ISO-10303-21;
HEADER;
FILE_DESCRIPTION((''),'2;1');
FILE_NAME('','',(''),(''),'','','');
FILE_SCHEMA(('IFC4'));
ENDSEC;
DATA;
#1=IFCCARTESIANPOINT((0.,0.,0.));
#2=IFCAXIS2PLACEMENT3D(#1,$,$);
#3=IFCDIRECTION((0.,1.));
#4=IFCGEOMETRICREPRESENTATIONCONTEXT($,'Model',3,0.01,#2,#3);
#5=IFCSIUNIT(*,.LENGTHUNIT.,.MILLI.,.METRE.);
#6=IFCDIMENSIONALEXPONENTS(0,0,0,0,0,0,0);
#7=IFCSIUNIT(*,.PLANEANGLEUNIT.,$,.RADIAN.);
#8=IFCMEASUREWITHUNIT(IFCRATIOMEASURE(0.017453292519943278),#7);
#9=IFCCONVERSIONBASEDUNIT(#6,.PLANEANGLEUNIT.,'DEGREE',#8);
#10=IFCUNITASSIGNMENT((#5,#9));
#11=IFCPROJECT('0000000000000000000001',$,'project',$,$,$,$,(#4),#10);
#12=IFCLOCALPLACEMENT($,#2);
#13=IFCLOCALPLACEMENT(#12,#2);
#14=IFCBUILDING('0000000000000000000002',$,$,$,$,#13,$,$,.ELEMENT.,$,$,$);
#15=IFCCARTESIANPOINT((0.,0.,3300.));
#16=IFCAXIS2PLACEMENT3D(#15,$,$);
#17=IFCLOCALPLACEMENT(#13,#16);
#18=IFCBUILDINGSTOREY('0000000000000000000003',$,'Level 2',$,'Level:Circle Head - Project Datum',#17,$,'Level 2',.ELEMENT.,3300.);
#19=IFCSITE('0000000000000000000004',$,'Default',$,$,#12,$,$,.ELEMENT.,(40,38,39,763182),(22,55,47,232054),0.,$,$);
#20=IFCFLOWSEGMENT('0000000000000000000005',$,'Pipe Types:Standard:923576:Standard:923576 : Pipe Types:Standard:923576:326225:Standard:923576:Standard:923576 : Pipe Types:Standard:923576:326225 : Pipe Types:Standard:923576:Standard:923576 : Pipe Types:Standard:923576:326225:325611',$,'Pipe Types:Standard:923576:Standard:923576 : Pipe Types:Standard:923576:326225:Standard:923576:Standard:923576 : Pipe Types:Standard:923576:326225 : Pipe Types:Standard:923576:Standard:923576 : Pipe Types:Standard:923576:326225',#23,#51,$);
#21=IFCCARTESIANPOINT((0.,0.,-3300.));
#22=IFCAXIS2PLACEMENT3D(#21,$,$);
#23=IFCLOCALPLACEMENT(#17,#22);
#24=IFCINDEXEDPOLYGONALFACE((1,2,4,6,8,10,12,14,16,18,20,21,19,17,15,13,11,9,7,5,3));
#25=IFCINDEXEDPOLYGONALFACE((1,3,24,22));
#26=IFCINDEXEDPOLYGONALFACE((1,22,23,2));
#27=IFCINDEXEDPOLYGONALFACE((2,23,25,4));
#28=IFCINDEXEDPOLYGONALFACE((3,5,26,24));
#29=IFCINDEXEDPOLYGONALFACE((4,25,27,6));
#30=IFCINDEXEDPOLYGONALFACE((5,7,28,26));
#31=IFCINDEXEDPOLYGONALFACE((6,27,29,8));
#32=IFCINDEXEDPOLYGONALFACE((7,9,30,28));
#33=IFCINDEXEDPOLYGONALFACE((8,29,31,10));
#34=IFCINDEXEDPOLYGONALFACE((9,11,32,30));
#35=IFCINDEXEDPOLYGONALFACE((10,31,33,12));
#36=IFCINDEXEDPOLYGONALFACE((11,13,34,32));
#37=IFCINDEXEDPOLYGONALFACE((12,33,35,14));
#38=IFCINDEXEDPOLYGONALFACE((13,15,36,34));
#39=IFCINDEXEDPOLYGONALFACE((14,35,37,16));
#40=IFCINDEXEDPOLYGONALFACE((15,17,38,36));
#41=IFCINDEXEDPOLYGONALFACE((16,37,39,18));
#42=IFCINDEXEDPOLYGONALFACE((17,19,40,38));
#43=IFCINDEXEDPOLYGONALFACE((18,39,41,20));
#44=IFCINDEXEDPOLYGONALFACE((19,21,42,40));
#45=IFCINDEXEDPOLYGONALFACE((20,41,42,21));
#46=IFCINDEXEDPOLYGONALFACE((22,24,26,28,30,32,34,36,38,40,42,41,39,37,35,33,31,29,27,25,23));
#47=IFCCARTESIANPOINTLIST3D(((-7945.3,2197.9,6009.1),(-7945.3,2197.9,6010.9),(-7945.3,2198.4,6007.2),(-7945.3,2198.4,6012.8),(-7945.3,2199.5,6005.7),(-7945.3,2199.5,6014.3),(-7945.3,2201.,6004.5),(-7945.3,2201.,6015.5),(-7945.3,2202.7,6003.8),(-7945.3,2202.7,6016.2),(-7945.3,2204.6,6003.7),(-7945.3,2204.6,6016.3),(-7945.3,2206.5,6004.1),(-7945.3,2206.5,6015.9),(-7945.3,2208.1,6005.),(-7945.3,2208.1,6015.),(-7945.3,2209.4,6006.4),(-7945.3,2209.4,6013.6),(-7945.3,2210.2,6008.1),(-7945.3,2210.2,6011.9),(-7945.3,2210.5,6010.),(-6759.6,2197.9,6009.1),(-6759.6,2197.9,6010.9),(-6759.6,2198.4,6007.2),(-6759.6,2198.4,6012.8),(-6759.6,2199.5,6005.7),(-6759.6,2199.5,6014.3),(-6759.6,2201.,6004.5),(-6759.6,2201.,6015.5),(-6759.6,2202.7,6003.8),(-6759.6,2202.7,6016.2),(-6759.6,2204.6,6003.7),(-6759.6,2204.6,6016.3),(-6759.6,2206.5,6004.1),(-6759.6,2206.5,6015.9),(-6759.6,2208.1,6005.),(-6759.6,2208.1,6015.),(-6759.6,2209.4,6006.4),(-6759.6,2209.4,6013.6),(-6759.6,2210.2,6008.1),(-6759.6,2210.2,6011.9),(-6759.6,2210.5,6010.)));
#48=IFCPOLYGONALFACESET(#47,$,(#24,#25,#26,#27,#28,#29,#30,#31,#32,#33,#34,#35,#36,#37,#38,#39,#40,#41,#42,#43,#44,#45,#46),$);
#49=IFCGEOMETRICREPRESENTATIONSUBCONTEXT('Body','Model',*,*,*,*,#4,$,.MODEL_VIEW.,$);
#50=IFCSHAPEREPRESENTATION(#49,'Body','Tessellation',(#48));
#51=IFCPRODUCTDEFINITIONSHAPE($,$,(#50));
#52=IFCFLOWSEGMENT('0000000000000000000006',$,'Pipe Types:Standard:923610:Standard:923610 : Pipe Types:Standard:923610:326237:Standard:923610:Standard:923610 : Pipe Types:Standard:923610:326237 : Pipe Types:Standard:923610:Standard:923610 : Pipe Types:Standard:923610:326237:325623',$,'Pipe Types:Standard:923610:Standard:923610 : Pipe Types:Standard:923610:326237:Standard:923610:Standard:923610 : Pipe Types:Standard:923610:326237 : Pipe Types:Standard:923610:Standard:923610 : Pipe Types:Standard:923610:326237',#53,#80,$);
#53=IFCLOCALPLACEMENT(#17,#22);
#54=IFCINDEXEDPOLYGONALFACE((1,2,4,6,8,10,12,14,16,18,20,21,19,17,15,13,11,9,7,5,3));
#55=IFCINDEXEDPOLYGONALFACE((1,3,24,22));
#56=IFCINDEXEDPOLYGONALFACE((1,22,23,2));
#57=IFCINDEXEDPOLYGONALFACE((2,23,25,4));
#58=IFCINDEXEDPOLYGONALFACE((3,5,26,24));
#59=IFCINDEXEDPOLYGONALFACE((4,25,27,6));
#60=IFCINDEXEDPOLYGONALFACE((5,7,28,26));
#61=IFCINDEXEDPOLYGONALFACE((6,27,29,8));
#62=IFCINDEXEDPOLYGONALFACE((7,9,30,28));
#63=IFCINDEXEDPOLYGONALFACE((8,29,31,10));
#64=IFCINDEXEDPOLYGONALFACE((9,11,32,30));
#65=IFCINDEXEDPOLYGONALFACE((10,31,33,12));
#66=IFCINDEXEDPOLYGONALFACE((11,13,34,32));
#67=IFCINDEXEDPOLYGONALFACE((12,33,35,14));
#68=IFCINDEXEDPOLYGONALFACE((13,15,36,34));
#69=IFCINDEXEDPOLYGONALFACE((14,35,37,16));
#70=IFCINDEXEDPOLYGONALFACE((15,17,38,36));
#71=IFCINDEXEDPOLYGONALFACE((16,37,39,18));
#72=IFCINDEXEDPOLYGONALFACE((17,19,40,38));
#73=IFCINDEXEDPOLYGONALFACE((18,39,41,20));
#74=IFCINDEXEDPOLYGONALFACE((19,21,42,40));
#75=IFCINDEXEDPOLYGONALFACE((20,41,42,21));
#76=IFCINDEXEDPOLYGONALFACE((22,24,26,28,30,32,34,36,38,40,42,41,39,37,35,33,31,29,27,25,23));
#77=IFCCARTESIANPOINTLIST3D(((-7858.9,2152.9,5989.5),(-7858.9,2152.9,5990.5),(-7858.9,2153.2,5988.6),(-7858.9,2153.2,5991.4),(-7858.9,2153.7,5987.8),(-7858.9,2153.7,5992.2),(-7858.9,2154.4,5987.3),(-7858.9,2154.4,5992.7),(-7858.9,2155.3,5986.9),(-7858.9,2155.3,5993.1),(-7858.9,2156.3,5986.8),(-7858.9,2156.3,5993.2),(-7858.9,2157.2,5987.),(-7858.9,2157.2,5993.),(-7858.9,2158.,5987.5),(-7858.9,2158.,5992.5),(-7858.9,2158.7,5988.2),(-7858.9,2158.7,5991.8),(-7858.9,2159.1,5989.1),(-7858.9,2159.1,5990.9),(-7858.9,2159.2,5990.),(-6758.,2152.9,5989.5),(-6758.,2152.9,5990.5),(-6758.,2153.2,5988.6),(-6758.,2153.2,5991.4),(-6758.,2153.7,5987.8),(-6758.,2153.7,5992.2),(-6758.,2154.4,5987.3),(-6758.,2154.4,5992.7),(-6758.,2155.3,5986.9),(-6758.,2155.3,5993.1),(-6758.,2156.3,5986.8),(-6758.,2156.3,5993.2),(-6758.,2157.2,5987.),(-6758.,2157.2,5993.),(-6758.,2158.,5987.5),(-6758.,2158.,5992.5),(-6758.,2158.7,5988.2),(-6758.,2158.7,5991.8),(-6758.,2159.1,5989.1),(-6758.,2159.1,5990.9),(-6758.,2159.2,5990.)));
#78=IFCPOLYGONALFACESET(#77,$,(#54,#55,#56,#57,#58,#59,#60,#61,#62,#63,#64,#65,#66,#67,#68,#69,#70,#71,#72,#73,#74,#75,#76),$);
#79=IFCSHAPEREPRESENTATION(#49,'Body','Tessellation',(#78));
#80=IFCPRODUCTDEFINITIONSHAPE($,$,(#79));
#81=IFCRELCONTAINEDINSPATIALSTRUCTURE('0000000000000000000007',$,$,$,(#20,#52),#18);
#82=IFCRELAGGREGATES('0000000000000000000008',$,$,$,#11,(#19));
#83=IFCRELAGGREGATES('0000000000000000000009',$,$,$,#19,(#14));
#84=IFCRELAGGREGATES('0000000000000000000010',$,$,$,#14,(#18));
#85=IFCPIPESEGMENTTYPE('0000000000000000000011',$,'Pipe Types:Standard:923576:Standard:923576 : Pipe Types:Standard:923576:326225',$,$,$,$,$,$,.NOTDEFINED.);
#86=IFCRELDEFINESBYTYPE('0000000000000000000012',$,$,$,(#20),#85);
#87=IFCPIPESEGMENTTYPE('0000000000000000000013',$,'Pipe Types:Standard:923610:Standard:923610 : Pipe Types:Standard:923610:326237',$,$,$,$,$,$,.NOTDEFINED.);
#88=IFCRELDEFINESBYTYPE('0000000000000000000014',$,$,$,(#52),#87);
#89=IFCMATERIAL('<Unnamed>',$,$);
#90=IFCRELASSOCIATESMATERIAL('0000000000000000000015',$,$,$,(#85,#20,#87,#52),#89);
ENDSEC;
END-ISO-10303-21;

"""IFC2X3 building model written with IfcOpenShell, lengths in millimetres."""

from ifc_helpers import new_model, entity, si_unit, converted_unit, direction, frame, origin, origin_2d_with_axis, place, context, subcontext, project, spatial, circle, extrude, source, transform, mapped, material, type_object, type_shapes, element, save


model = new_model("IFC2X3")

# Units and contexts
model_context = context("Model", 3, precision=0.01, world=origin(), true_north=direction((0.0, 1.0)))
body_context = subcontext(model_context, "Body", "Model", "MODEL_VIEW")
ifc_project = project(units=[si_unit("LENGTHUNIT", "METRE", prefix="MILLI"), converted_unit("PLANEANGLEUNIT", "DEGREE", entity("IfcRatioMeasure", 0.017453292519943278), si_unit("PLANEANGLEUNIT", "RADIAN"), dimensions=[0, 0, 0, 0, 0, 0, 0])], contexts=[model_context])

# Site, building, storey
site_placement = place(None, origin())
site = spatial("IfcSite", under=ifc_project, at=site_placement, Name="Default", CompositionType="ELEMENT", RefLatitude=(40, 38, 39, 763182), RefLongitude=(22, 55, 47, 232054), RefElevation=0.0)
building_placement = place(site_placement, origin())
building = spatial("IfcBuilding", under=site, at=building_placement, CompositionType="ELEMENT")
storey_placement = place(building_placement, frame((0.0, 0.0, 3300.0)))
storey = spatial("IfcBuildingStorey", under=building, at=storey_placement, Name="Level 2", ObjectType="Level:Circle Head - Project Datum", LongName="Level 2", CompositionType="ELEMENT", Elevation=3300.0)

# Flow segments
ifc_material = material(Name="<Unnamed>")
pipe_segment_type_1 = type_object("IfcPipeSegmentType", Name="Pipe Types:Standard:923576:Standard:923576 : Pipe Types:Standard:923576:326225", PredefinedType="NOTDEFINED", material=ifc_material)
shared_shape_1 = source(origin(), body_context, "Body", "SweptSolid", [
    extrude(circle(Radius=6.3, at=origin_2d_with_axis()), frame((-7945.3, 2204.2, 6010.0), z_axis=(1.0, 0.0, 0.0), x_axis=(0.0, 1.0, 0.0)), (0.0, 0.0, 1.0), 1185.7),
])
type_shapes(pipe_segment_type_1, [shared_shape_1])
flow_segment_1_placement = place(storey_placement, frame((0.0, 0.0, -3300.0)))
element("IfcFlowSegment", 1, at=flow_segment_1_placement, inside=storey, type_object=pipe_segment_type_1, material=ifc_material, Name="Pipe Types:Standard:923576:Standard:923576 : Pipe Types:Standard:923576:326225:Standard:923576:Standard:923576 : Pipe Types:Standard:923576:326225 : Pipe Types:Standard:923576:Standard:923576 : Pipe Types:Standard:923576:326225:325611", ObjectType="Pipe Types:Standard:923576:Standard:923576 : Pipe Types:Standard:923576:326225:Standard:923576:Standard:923576 : Pipe Types:Standard:923576:326225 : Pipe Types:Standard:923576:Standard:923576 : Pipe Types:Standard:923576:326225", context=body_context, shape_type="MappedRepresentation", body=[
    mapped(shared_shape_1, transform((0.0, 0.0, 0.0), scale=1.0)),
])
pipe_segment_type_2 = type_object("IfcPipeSegmentType", Name="Pipe Types:Standard:923610:Standard:923610 : Pipe Types:Standard:923610:326237", PredefinedType="NOTDEFINED", material=ifc_material)
shared_shape_2 = source(origin(), body_context, "Body", "SweptSolid", [
    extrude(circle(Radius=3.2, at=origin_2d_with_axis()), frame((-7858.9, 2156.0, 5990.0), z_axis=(1.0, 0.0, 0.0), x_axis=(0.0, 1.0, 0.0)), (0.0, 0.0, 1.0), 1101.0),
])
type_shapes(pipe_segment_type_2, [shared_shape_2])
flow_segment_2_placement = place(storey_placement, frame((0.0, 0.0, -3300.0)))
element("IfcFlowSegment", 2, at=flow_segment_2_placement, inside=storey, type_object=pipe_segment_type_2, material=ifc_material, Name="Pipe Types:Standard:923610:Standard:923610 : Pipe Types:Standard:923610:326237:Standard:923610:Standard:923610 : Pipe Types:Standard:923610:326237 : Pipe Types:Standard:923610:Standard:923610 : Pipe Types:Standard:923610:326237:325623", ObjectType="Pipe Types:Standard:923610:Standard:923610 : Pipe Types:Standard:923610:326237:Standard:923610:Standard:923610 : Pipe Types:Standard:923610:326237 : Pipe Types:Standard:923610:Standard:923610 : Pipe Types:Standard:923610:326237", context=body_context, shape_type="MappedRepresentation", body=[
    mapped(shared_shape_2, transform((0.0, 0.0, 0.0), scale=1.0)),
])

save(model, "model.ifc")
